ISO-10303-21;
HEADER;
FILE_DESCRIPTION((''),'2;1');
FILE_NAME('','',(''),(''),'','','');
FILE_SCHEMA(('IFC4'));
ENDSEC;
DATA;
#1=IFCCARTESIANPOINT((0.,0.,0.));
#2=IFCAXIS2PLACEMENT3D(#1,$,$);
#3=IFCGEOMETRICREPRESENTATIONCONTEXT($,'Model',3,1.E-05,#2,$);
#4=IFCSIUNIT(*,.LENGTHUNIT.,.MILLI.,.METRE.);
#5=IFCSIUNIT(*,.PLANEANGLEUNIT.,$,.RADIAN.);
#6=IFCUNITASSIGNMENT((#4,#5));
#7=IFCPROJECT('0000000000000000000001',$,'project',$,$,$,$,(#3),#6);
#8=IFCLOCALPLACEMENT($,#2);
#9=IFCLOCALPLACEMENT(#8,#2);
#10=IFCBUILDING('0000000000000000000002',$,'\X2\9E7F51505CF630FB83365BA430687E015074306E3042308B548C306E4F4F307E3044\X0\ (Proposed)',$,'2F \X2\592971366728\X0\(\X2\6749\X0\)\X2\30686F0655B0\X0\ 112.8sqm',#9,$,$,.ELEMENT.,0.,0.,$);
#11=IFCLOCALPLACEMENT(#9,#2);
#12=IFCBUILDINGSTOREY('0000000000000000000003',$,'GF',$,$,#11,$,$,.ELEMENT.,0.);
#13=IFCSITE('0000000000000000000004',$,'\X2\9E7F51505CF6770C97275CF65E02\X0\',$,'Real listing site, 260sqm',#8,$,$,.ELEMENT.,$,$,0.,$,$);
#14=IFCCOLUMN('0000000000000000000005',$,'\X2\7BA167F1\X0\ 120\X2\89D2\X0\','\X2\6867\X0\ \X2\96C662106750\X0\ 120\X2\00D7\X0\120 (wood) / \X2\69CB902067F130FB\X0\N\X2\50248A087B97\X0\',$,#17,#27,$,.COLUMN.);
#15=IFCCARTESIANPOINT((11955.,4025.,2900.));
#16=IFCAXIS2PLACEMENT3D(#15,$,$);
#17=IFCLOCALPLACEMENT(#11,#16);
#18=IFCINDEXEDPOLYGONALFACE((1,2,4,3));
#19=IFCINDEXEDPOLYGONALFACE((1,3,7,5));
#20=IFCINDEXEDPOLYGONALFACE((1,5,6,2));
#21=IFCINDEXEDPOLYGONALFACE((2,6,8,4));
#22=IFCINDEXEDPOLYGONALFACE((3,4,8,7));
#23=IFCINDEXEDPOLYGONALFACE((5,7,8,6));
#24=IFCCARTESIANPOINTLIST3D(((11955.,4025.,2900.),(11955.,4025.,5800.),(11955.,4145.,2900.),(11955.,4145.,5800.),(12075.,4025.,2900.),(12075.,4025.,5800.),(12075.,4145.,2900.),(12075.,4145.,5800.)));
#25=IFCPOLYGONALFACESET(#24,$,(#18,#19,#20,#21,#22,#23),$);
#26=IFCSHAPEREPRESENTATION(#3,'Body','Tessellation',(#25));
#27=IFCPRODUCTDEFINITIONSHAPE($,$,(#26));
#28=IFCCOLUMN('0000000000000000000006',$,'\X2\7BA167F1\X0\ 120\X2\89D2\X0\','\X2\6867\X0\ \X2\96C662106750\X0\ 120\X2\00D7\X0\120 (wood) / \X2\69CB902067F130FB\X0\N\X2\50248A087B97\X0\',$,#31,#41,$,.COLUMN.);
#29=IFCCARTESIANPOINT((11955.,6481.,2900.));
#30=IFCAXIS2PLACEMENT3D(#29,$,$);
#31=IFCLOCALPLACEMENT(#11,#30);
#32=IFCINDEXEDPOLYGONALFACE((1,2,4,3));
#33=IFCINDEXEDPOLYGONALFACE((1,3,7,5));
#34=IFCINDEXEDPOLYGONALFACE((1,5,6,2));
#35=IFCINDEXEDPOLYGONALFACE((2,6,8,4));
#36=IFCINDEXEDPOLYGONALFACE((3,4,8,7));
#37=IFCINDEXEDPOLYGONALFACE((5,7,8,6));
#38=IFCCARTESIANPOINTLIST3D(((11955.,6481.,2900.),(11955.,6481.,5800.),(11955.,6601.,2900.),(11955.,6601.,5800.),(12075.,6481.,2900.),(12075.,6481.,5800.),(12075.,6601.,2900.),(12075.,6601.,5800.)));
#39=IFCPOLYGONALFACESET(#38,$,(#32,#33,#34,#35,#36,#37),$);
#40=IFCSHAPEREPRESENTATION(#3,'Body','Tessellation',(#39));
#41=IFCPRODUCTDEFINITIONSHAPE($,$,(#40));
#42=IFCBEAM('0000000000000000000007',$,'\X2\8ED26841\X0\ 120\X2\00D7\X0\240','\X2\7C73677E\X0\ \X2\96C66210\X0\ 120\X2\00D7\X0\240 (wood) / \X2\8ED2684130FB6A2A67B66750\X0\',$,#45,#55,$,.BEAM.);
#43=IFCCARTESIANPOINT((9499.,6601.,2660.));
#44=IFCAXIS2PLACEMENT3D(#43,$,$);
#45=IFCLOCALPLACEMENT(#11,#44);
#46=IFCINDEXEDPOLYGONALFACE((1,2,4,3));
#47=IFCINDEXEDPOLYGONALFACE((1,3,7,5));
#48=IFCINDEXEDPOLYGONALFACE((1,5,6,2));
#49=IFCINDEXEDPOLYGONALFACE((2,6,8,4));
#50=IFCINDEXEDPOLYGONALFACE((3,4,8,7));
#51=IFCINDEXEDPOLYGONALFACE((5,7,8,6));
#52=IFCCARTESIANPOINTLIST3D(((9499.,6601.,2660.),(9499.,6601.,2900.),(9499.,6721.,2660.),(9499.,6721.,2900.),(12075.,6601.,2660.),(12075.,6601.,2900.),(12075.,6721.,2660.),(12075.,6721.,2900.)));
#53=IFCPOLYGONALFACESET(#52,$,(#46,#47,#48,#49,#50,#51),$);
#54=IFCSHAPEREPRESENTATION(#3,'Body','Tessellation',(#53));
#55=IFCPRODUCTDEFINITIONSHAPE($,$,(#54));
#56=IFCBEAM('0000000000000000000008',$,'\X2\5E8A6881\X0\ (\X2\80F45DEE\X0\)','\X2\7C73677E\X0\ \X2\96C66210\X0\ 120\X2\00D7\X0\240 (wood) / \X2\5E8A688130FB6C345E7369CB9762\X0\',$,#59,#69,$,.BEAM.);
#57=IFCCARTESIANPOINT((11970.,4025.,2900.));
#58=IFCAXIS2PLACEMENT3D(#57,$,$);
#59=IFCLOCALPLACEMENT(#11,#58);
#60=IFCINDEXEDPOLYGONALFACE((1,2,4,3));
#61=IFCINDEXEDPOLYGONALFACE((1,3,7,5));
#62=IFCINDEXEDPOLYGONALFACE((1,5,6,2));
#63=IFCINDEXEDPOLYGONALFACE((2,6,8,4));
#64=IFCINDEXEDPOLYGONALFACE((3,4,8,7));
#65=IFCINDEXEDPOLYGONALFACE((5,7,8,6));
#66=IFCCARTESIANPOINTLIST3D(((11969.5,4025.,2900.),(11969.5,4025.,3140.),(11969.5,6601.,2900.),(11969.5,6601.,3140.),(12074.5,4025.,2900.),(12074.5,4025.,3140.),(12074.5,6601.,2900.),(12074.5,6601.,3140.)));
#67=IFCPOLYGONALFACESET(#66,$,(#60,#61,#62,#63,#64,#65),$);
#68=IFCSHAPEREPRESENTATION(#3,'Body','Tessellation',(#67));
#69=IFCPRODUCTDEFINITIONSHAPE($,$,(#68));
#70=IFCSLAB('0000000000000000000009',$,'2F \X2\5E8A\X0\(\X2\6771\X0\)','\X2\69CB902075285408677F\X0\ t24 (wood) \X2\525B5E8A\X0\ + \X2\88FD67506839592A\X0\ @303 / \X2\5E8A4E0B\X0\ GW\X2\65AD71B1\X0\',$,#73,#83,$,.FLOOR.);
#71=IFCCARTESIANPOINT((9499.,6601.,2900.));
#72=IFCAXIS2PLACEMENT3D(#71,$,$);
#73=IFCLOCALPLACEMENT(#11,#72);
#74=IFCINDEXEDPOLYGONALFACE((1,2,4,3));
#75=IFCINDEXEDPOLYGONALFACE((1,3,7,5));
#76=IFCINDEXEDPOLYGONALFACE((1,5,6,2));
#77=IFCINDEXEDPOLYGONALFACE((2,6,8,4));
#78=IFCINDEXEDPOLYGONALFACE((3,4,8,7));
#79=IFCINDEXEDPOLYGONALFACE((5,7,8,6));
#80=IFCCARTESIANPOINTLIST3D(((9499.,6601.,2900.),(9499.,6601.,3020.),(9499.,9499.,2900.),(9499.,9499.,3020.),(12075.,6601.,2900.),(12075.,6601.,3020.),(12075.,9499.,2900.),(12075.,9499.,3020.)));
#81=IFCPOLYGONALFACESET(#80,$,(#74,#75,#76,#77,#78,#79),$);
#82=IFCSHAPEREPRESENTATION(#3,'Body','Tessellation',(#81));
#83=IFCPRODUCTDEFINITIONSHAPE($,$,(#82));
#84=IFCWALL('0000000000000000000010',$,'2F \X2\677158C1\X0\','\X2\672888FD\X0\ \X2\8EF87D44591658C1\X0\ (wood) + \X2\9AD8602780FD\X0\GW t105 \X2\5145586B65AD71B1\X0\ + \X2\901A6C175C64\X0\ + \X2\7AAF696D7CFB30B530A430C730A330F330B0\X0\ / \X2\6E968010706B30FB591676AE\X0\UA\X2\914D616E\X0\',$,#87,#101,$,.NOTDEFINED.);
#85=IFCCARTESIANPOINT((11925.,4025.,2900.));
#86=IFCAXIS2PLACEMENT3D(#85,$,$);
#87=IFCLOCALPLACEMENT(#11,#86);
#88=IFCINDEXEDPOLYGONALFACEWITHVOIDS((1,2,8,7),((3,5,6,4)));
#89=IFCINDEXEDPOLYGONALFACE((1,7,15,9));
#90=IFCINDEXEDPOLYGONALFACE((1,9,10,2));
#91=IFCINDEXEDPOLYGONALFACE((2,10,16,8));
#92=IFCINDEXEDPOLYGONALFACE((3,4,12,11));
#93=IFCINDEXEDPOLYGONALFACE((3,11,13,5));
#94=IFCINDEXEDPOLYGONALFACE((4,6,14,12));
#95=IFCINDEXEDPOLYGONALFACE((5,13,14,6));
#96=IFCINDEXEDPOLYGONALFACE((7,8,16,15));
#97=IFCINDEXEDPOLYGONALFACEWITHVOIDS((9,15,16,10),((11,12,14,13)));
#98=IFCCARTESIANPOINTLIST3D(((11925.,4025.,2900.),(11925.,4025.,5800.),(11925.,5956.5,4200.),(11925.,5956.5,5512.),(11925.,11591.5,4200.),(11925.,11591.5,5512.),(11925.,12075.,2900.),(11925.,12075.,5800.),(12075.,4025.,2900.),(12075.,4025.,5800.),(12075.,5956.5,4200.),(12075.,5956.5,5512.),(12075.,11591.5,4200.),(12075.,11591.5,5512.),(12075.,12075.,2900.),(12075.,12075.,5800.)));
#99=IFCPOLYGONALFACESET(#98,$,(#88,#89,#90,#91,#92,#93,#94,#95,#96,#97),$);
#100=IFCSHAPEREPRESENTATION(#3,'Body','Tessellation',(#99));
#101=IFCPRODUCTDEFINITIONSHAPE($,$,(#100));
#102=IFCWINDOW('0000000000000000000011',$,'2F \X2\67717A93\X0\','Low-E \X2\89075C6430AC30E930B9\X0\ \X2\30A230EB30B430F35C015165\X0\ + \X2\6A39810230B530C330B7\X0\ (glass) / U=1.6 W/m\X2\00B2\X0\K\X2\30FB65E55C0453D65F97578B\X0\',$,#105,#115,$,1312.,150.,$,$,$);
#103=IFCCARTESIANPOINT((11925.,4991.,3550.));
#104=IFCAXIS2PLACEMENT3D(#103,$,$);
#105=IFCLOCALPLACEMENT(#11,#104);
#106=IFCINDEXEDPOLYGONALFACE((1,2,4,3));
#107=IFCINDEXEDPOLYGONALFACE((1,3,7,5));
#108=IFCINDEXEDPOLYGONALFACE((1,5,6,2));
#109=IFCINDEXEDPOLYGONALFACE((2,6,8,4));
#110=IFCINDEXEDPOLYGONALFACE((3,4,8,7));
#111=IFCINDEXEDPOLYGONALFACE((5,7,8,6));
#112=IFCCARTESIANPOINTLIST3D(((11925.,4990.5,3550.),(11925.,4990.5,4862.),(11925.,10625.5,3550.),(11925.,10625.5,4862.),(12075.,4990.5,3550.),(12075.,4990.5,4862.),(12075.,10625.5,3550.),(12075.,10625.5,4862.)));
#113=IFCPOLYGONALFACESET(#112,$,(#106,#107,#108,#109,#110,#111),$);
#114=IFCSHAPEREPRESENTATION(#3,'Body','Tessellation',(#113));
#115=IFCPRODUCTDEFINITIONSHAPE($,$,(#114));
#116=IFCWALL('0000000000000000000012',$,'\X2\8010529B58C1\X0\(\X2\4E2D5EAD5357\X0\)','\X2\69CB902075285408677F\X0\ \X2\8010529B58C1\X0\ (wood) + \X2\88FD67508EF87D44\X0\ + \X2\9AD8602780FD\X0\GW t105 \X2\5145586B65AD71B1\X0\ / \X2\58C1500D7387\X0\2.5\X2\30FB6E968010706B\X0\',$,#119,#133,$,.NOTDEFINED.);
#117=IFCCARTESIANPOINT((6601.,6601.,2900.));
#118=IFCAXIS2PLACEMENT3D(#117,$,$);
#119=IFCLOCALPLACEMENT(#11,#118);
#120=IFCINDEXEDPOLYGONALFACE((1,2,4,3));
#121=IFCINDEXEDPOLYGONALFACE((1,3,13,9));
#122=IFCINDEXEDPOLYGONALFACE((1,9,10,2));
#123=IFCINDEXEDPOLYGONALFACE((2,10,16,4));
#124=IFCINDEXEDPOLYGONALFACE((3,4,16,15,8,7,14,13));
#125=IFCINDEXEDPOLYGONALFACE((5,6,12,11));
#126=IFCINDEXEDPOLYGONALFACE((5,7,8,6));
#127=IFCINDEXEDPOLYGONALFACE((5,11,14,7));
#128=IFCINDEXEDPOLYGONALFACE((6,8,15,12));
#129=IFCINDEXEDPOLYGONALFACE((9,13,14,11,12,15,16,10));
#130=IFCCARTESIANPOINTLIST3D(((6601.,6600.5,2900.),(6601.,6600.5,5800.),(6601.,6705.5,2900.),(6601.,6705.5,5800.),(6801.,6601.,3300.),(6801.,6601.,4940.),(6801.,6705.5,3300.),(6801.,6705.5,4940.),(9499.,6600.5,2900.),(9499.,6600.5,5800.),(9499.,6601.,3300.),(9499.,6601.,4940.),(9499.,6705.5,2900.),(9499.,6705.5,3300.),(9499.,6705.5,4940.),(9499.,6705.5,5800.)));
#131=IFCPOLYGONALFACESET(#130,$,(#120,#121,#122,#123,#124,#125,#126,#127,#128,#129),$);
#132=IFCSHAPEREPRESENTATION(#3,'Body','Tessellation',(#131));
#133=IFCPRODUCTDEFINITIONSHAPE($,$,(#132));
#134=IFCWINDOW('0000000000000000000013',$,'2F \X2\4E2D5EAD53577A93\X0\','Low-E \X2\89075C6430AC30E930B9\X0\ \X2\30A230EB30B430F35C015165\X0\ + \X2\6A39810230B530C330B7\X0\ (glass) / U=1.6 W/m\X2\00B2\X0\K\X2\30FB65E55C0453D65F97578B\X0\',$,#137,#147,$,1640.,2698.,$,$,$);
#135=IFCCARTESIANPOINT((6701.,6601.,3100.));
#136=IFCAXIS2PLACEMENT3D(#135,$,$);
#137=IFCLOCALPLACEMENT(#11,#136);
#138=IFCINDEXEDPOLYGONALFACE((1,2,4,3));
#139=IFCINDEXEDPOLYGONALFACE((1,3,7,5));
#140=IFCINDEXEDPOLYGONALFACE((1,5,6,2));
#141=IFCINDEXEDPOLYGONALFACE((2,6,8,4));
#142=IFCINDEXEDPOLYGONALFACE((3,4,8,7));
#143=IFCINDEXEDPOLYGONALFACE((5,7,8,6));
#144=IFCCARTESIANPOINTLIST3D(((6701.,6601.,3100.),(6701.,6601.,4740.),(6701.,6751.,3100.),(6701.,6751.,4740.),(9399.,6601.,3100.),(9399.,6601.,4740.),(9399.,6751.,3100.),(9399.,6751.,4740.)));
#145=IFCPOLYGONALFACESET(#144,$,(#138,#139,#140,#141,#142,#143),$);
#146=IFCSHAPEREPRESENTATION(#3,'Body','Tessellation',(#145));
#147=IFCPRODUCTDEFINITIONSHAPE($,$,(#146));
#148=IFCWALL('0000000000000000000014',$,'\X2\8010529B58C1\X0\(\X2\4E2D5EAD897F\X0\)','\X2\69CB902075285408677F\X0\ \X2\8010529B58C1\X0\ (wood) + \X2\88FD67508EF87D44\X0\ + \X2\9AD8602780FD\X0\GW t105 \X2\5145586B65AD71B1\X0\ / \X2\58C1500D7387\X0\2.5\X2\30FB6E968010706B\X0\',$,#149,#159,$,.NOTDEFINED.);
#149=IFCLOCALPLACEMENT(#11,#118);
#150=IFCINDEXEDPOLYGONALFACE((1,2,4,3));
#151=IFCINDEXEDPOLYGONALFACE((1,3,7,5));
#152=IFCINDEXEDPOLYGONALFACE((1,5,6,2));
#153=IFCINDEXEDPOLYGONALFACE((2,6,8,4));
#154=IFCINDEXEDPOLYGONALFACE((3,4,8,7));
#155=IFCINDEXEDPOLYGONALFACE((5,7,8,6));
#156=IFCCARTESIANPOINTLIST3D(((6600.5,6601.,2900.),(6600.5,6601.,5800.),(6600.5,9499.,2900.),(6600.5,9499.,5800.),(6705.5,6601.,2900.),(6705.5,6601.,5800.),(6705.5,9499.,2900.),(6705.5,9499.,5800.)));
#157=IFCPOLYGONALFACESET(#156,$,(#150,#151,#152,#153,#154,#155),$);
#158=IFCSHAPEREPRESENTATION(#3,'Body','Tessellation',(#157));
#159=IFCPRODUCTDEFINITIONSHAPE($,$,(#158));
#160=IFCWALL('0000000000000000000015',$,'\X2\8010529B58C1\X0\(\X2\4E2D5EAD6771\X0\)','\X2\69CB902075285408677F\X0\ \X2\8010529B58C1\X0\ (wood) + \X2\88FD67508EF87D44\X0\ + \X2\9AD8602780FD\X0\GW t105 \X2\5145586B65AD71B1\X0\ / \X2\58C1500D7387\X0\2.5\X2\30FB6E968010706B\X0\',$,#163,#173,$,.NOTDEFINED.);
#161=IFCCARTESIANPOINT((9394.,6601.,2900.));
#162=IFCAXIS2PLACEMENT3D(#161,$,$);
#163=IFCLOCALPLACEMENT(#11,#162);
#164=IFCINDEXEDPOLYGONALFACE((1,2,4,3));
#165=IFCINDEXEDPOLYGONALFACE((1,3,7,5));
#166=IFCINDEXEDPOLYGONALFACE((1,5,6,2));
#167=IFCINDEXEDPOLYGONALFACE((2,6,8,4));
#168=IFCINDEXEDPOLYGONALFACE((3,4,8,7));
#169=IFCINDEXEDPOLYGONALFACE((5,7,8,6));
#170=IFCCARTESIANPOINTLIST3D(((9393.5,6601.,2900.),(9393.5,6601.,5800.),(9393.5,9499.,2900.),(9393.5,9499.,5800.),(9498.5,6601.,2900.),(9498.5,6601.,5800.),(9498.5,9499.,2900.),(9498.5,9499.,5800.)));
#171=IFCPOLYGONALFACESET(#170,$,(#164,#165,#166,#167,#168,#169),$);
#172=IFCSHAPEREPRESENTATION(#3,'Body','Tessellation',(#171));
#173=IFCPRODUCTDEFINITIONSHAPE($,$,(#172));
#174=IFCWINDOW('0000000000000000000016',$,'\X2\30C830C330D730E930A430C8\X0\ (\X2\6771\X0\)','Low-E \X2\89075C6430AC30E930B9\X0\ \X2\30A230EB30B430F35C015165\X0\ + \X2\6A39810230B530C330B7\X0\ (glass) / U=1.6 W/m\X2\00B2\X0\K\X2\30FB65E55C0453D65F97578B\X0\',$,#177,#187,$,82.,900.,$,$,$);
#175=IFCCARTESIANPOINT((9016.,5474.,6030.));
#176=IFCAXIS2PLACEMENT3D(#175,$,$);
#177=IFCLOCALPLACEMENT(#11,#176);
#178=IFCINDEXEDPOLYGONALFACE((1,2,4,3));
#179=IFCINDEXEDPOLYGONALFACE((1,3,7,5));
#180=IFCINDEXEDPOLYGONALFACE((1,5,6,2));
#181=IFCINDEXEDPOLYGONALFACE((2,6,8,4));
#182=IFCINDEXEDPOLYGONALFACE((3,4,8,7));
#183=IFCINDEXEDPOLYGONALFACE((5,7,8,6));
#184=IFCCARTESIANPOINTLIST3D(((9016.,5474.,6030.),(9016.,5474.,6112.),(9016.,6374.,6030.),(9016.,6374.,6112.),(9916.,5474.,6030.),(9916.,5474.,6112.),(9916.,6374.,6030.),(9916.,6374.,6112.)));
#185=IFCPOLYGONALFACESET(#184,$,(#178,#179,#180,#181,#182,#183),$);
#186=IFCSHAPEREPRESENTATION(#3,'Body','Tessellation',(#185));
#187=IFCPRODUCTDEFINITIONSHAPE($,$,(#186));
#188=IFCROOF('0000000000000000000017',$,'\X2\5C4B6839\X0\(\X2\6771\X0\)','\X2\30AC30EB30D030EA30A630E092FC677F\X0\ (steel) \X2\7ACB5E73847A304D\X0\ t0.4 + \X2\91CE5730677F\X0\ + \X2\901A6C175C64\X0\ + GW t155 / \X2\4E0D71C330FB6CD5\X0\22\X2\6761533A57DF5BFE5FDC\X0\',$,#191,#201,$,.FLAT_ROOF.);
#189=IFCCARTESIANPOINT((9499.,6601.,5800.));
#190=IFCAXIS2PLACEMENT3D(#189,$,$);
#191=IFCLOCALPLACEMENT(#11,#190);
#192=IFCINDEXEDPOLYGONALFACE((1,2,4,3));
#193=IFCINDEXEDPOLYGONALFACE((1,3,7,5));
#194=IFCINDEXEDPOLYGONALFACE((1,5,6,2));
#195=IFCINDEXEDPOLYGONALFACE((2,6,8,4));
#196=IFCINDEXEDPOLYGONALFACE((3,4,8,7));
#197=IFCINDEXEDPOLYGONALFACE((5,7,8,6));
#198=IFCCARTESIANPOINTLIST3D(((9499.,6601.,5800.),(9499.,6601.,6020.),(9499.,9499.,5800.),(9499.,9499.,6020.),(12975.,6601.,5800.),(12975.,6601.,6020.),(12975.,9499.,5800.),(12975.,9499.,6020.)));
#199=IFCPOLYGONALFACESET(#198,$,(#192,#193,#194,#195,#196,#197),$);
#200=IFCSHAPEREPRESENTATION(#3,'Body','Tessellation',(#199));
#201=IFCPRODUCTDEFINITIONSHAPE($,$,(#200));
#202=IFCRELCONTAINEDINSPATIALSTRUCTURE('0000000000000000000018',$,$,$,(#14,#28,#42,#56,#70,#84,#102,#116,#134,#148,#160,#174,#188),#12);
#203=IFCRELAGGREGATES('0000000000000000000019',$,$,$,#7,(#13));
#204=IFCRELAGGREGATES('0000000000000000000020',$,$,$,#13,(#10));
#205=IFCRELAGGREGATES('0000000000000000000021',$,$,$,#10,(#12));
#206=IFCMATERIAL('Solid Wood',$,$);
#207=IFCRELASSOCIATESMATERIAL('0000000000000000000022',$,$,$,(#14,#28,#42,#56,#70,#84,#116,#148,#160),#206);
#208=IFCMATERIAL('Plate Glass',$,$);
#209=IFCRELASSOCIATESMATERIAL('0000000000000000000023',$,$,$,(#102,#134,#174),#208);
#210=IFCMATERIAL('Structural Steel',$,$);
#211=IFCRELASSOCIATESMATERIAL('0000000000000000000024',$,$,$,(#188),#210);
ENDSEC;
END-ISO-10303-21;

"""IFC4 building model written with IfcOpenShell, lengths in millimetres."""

from ifc_helpers import new_model, si_unit, frame, frame_2d, origin, place, context, project, spatial, rectangle, extrude, material, element, fill, save


model = new_model("IFC4")

# Units and contexts
model_context = context("Model", 3, precision=1e-05, world=origin())
ifc_project = project(units=[si_unit("LENGTHUNIT", "METRE", prefix="MILLI"), si_unit("PLANEANGLEUNIT", "RADIAN")], contexts=[model_context])

# Site, building, storey
site_placement = place(None, origin())
site = spatial("IfcSite", under=ifc_project, at=site_placement, Name="鹿児島県霧島市", ObjectType="Real listing site, 260sqm", CompositionType="ELEMENT", RefElevation=0.0)
building_placement = place(site_placement, origin())
building = spatial("IfcBuilding", under=site, at=building_placement, Name="鹿児島・茶室と縁側のある和の住まい (Proposed)", ObjectType="2F 天然木(杉)と漆喰 112.8sqm", CompositionType="ELEMENT", ElevationOfRefHeight=0.0, ElevationOfTerrain=0.0)
storey_placement = place(building_placement, origin())
storey = spatial("IfcBuildingStorey", under=building, at=storey_placement, Name="GF", CompositionType="ELEMENT", Elevation=0.0)

# Columns
ifc_material_1 = material(Name="Solid Wood")
column_1_placement = place(storey_placement, frame((11955.0, 4025.0, 2900.0)))
element("IfcColumn", 1, at=column_1_placement, inside=storey, material=ifc_material_1, Name="管柱 120角", Description="桧 集成材 120×120 (wood) / 構造柱・N値計算", PredefinedType="COLUMN", context=model_context, shape_type="SweptSolid", body=[
    extrude(rectangle(XDim=120.0, YDim=120.0, at=frame_2d((60.0, 60.0))), frame((11955.0, 4025.0, 2900.0)), (0.0, 0.0, 1.0), 2900.0),
])
column_2_placement = place(storey_placement, frame((11955.0, 6481.0, 2900.0)))
element("IfcColumn", 2, at=column_2_placement, inside=storey, material=ifc_material_1, Name="管柱 120角", Description="桧 集成材 120×120 (wood) / 構造柱・N値計算", PredefinedType="COLUMN", context=model_context, shape_type="SweptSolid", body=[
    extrude(rectangle(XDim=120.0, YDim=120.0, at=frame_2d((60.0, 60.0))), frame((11955.0, 6481.0, 2900.0)), (0.0, 0.0, 1.0), 2900.0),
])

# Beams
beam_1_placement = place(storey_placement, frame((9499.0, 6601.0, 2660.0)))
element("IfcBeam", 3, at=beam_1_placement, inside=storey, material=ifc_material_1, Name="軒桁 120×240", Description="米松 集成 120×240 (wood) / 軒桁・横架材", PredefinedType="BEAM", context=model_context, shape_type="SweptSolid", body=[
    extrude(rectangle(XDim=2576.0, YDim=120.0, at=frame_2d((1288.0, 60.0))), frame((9499.0, 6601.0, 2660.0)), (0.0, 0.0, 1.0), 240.0),
])
beam_2_placement = place(storey_placement, frame((11970.0, 4025.0, 2900.0)))
element("IfcBeam", 4, at=beam_2_placement, inside=storey, material=ifc_material_1, Name="床梁 (胴差)", Description="米松 集成 120×240 (wood) / 床梁・水平構面", PredefinedType="BEAM", context=model_context, shape_type="SweptSolid", body=[
    extrude(rectangle(XDim=105.0, YDim=2576.0, at=frame_2d((52.0, 1288.0))), frame((11970.0, 4025.0, 2900.0)), (0.0, 0.0, 1.0), 240.0),
])

# Slab
slab_placement = place(storey_placement, frame((9499.0, 6601.0, 2900.0)))
element("IfcSlab", 5, at=slab_placement, inside=storey, material=ifc_material_1, Name="2F 床(東)", Description="構造用合板 t24 (wood) 剛床 + 製材根太 @303 / 床下 GW断熱", PredefinedType="FLOOR", context=model_context, shape_type="SweptSolid", body=[
    extrude(rectangle(XDim=2576.0, YDim=2898.0, at=frame_2d((1288.0, 1449.0))), frame((9499.0, 6601.0, 2900.0)), (0.0, 0.0, 1.0), 120.0),
])

# Walls, openings, windows
wall_1_placement = place(storey_placement, frame((11925.0, 4025.0, 2900.0)))
wall_1 = element("IfcWall", 6, at=wall_1_placement, inside=storey, material=ifc_material_1, Name="2F 東壁", Description="木製 軸組外壁 (wood) + 高性能GW t105 充填断熱 + 通気層 + 窯業系サイディング / 準耐火・外皮UA配慮", PredefinedType="NOTDEFINED", context=model_context, shape_type="SweptSolid", body=[
    extrude(rectangle(XDim=150.0, YDim=8050.0, at=frame_2d((75.0, 4025.0))), frame((11925.0, 4025.0, 2900.0)), (0.0, 0.0, 1.0), 2900.0),
])
opening_1_placement = place(storey_placement, frame((11925.0, 4991.0, 3550.0)))
opening_1 = element("IfcOpeningElement", 7, at=opening_1_placement, cuts=wall_1, PredefinedType="NOTDEFINED", context=model_context, shape_type="SweptSolid", body=[
    extrude(rectangle(XDim=150.0, YDim=5635.0, at=frame_2d((75.0, 2817.0))), frame((11925.0, 4991.0, 3550.0)), (0.0, 0.0, 1.0), 1312.0),
])
ifc_material_2 = material(Name="Plate Glass")
window_1_placement = place(storey_placement, frame((11925.0, 4991.0, 3550.0)))
window_1 = element("IfcWindow", 8, at=window_1_placement, inside=storey, material=ifc_material_2, Name="2F 東窓", Description="Low-E 複層ガラス アルゴン封入 + 樹脂サッシ (glass) / U=1.6 W/m²K・日射取得型", OverallHeight=1312.0, OverallWidth=150.0, context=model_context, shape_type="SweptSolid", body=[
    extrude(rectangle(XDim=150.0, YDim=5635.0, at=frame_2d((75.0, 2817.0))), frame((11925.0, 4991.0, 3550.0)), (0.0, 0.0, 1.0), 1312.0),
])
fill(opening_1, window_1)
wall_2_placement = place(storey_placement, frame((6601.0, 6601.0, 2900.0)))
wall_2 = element("IfcWall", 9, at=wall_2_placement, inside=storey, material=ifc_material_1, Name="耐力壁(中庭南)", Description="構造用合板 耐力壁 (wood) + 製材軸組 + 高性能GW t105 充填断熱 / 壁倍率2.5・準耐火", PredefinedType="NOTDEFINED", context=model_context, shape_type="SweptSolid", body=[
    extrude(rectangle(XDim=2898.0, YDim=105.0, at=frame_2d((1449.0, 52.0))), frame((6601.0, 6601.0, 2900.0)), (0.0, 0.0, 1.0), 2900.0),
])
opening_2_placement = place(storey_placement, frame((6701.0, 6601.0, 3100.0)))
opening_2 = element("IfcOpeningElement", 10, at=opening_2_placement, cuts=wall_2, PredefinedType="NOTDEFINED", context=model_context, shape_type="SweptSolid", body=[
    extrude(rectangle(XDim=2698.0, YDim=150.0, at=frame_2d((1349.0, 75.0))), frame((6701.0, 6601.0, 3100.0)), (0.0, 0.0, 1.0), 1640.0),
])
window_2_placement = place(storey_placement, frame((6701.0, 6601.0, 3100.0)))
window_2 = element("IfcWindow", 11, at=window_2_placement, inside=storey, material=ifc_material_2, Name="2F 中庭南窓", Description="Low-E 複層ガラス アルゴン封入 + 樹脂サッシ (glass) / U=1.6 W/m²K・日射取得型", OverallHeight=1640.0, OverallWidth=2698.0, context=model_context, shape_type="SweptSolid", body=[
    extrude(rectangle(XDim=2698.0, YDim=150.0, at=frame_2d((1349.0, 75.0))), frame((6701.0, 6601.0, 3100.0)), (0.0, 0.0, 1.0), 1640.0),
])
fill(opening_2, window_2)

# Walls
wall_3_placement = place(storey_placement, frame((6601.0, 6601.0, 2900.0)))
element("IfcWall", 12, at=wall_3_placement, inside=storey, material=ifc_material_1, Name="耐力壁(中庭西)", Description="構造用合板 耐力壁 (wood) + 製材軸組 + 高性能GW t105 充填断熱 / 壁倍率2.5・準耐火", PredefinedType="NOTDEFINED", context=model_context, shape_type="SweptSolid", body=[
    extrude(rectangle(XDim=105.0, YDim=2898.0, at=frame_2d((52.0, 1449.0))), frame((6601.0, 6601.0, 2900.0)), (0.0, 0.0, 1.0), 2900.0),
])
wall_4_placement = place(storey_placement, frame((9394.0, 6601.0, 2900.0)))
element("IfcWall", 13, at=wall_4_placement, inside=storey, material=ifc_material_1, Name="耐力壁(中庭東)", Description="構造用合板 耐力壁 (wood) + 製材軸組 + 高性能GW t105 充填断熱 / 壁倍率2.5・準耐火", PredefinedType="NOTDEFINED", context=model_context, shape_type="SweptSolid", body=[
    extrude(rectangle(XDim=105.0, YDim=2898.0, at=frame_2d((52.0, 1449.0))), frame((9394.0, 6601.0, 2900.0)), (0.0, 0.0, 1.0), 2900.0),
])

# Window
window_3_placement = place(storey_placement, frame((9016.0, 5474.0, 6030.0)))
element("IfcWindow", 14, at=window_3_placement, inside=storey, material=ifc_material_2, Name="トップライト (東)", Description="Low-E 複層ガラス アルゴン封入 + 樹脂サッシ (glass) / U=1.6 W/m²K・日射取得型", OverallHeight=82.0, OverallWidth=900.0, context=model_context, shape_type="SweptSolid", body=[
    extrude(rectangle(XDim=900.0, YDim=900.0, at=frame_2d((450.0, 450.0))), frame((9016.0, 5474.0, 6030.0)), (0.0, 0.0, 1.0), 82.0),
])

# Roof
ifc_material_3 = material(Name="Structural Steel")
for number, where, name in (
    (15, (9499.0, 6601.0, 5800.0), "屋根(東)"),
):
    element("IfcRoof", number, at=place(storey_placement, frame(where)), inside=storey, material=ifc_material_3, Name=name, Description="ガルバリウム鋼板 (steel) 立平葺き t0.4 + 野地板 + 通気層 + GW t155 / 不燃・法22条区域対応", PredefinedType="FLAT_ROOF", context=model_context, shape_type="SweptSolid", body=[
        extrude(rectangle(XDim=3476.0, YDim=2898.0, at=frame_2d((1738.0, 1449.0))), frame((9499.0, 6601.0, 5800.0)), (0.0, 0.0, 1.0), 220.0),
    ])

save(model, "model.ifc")
